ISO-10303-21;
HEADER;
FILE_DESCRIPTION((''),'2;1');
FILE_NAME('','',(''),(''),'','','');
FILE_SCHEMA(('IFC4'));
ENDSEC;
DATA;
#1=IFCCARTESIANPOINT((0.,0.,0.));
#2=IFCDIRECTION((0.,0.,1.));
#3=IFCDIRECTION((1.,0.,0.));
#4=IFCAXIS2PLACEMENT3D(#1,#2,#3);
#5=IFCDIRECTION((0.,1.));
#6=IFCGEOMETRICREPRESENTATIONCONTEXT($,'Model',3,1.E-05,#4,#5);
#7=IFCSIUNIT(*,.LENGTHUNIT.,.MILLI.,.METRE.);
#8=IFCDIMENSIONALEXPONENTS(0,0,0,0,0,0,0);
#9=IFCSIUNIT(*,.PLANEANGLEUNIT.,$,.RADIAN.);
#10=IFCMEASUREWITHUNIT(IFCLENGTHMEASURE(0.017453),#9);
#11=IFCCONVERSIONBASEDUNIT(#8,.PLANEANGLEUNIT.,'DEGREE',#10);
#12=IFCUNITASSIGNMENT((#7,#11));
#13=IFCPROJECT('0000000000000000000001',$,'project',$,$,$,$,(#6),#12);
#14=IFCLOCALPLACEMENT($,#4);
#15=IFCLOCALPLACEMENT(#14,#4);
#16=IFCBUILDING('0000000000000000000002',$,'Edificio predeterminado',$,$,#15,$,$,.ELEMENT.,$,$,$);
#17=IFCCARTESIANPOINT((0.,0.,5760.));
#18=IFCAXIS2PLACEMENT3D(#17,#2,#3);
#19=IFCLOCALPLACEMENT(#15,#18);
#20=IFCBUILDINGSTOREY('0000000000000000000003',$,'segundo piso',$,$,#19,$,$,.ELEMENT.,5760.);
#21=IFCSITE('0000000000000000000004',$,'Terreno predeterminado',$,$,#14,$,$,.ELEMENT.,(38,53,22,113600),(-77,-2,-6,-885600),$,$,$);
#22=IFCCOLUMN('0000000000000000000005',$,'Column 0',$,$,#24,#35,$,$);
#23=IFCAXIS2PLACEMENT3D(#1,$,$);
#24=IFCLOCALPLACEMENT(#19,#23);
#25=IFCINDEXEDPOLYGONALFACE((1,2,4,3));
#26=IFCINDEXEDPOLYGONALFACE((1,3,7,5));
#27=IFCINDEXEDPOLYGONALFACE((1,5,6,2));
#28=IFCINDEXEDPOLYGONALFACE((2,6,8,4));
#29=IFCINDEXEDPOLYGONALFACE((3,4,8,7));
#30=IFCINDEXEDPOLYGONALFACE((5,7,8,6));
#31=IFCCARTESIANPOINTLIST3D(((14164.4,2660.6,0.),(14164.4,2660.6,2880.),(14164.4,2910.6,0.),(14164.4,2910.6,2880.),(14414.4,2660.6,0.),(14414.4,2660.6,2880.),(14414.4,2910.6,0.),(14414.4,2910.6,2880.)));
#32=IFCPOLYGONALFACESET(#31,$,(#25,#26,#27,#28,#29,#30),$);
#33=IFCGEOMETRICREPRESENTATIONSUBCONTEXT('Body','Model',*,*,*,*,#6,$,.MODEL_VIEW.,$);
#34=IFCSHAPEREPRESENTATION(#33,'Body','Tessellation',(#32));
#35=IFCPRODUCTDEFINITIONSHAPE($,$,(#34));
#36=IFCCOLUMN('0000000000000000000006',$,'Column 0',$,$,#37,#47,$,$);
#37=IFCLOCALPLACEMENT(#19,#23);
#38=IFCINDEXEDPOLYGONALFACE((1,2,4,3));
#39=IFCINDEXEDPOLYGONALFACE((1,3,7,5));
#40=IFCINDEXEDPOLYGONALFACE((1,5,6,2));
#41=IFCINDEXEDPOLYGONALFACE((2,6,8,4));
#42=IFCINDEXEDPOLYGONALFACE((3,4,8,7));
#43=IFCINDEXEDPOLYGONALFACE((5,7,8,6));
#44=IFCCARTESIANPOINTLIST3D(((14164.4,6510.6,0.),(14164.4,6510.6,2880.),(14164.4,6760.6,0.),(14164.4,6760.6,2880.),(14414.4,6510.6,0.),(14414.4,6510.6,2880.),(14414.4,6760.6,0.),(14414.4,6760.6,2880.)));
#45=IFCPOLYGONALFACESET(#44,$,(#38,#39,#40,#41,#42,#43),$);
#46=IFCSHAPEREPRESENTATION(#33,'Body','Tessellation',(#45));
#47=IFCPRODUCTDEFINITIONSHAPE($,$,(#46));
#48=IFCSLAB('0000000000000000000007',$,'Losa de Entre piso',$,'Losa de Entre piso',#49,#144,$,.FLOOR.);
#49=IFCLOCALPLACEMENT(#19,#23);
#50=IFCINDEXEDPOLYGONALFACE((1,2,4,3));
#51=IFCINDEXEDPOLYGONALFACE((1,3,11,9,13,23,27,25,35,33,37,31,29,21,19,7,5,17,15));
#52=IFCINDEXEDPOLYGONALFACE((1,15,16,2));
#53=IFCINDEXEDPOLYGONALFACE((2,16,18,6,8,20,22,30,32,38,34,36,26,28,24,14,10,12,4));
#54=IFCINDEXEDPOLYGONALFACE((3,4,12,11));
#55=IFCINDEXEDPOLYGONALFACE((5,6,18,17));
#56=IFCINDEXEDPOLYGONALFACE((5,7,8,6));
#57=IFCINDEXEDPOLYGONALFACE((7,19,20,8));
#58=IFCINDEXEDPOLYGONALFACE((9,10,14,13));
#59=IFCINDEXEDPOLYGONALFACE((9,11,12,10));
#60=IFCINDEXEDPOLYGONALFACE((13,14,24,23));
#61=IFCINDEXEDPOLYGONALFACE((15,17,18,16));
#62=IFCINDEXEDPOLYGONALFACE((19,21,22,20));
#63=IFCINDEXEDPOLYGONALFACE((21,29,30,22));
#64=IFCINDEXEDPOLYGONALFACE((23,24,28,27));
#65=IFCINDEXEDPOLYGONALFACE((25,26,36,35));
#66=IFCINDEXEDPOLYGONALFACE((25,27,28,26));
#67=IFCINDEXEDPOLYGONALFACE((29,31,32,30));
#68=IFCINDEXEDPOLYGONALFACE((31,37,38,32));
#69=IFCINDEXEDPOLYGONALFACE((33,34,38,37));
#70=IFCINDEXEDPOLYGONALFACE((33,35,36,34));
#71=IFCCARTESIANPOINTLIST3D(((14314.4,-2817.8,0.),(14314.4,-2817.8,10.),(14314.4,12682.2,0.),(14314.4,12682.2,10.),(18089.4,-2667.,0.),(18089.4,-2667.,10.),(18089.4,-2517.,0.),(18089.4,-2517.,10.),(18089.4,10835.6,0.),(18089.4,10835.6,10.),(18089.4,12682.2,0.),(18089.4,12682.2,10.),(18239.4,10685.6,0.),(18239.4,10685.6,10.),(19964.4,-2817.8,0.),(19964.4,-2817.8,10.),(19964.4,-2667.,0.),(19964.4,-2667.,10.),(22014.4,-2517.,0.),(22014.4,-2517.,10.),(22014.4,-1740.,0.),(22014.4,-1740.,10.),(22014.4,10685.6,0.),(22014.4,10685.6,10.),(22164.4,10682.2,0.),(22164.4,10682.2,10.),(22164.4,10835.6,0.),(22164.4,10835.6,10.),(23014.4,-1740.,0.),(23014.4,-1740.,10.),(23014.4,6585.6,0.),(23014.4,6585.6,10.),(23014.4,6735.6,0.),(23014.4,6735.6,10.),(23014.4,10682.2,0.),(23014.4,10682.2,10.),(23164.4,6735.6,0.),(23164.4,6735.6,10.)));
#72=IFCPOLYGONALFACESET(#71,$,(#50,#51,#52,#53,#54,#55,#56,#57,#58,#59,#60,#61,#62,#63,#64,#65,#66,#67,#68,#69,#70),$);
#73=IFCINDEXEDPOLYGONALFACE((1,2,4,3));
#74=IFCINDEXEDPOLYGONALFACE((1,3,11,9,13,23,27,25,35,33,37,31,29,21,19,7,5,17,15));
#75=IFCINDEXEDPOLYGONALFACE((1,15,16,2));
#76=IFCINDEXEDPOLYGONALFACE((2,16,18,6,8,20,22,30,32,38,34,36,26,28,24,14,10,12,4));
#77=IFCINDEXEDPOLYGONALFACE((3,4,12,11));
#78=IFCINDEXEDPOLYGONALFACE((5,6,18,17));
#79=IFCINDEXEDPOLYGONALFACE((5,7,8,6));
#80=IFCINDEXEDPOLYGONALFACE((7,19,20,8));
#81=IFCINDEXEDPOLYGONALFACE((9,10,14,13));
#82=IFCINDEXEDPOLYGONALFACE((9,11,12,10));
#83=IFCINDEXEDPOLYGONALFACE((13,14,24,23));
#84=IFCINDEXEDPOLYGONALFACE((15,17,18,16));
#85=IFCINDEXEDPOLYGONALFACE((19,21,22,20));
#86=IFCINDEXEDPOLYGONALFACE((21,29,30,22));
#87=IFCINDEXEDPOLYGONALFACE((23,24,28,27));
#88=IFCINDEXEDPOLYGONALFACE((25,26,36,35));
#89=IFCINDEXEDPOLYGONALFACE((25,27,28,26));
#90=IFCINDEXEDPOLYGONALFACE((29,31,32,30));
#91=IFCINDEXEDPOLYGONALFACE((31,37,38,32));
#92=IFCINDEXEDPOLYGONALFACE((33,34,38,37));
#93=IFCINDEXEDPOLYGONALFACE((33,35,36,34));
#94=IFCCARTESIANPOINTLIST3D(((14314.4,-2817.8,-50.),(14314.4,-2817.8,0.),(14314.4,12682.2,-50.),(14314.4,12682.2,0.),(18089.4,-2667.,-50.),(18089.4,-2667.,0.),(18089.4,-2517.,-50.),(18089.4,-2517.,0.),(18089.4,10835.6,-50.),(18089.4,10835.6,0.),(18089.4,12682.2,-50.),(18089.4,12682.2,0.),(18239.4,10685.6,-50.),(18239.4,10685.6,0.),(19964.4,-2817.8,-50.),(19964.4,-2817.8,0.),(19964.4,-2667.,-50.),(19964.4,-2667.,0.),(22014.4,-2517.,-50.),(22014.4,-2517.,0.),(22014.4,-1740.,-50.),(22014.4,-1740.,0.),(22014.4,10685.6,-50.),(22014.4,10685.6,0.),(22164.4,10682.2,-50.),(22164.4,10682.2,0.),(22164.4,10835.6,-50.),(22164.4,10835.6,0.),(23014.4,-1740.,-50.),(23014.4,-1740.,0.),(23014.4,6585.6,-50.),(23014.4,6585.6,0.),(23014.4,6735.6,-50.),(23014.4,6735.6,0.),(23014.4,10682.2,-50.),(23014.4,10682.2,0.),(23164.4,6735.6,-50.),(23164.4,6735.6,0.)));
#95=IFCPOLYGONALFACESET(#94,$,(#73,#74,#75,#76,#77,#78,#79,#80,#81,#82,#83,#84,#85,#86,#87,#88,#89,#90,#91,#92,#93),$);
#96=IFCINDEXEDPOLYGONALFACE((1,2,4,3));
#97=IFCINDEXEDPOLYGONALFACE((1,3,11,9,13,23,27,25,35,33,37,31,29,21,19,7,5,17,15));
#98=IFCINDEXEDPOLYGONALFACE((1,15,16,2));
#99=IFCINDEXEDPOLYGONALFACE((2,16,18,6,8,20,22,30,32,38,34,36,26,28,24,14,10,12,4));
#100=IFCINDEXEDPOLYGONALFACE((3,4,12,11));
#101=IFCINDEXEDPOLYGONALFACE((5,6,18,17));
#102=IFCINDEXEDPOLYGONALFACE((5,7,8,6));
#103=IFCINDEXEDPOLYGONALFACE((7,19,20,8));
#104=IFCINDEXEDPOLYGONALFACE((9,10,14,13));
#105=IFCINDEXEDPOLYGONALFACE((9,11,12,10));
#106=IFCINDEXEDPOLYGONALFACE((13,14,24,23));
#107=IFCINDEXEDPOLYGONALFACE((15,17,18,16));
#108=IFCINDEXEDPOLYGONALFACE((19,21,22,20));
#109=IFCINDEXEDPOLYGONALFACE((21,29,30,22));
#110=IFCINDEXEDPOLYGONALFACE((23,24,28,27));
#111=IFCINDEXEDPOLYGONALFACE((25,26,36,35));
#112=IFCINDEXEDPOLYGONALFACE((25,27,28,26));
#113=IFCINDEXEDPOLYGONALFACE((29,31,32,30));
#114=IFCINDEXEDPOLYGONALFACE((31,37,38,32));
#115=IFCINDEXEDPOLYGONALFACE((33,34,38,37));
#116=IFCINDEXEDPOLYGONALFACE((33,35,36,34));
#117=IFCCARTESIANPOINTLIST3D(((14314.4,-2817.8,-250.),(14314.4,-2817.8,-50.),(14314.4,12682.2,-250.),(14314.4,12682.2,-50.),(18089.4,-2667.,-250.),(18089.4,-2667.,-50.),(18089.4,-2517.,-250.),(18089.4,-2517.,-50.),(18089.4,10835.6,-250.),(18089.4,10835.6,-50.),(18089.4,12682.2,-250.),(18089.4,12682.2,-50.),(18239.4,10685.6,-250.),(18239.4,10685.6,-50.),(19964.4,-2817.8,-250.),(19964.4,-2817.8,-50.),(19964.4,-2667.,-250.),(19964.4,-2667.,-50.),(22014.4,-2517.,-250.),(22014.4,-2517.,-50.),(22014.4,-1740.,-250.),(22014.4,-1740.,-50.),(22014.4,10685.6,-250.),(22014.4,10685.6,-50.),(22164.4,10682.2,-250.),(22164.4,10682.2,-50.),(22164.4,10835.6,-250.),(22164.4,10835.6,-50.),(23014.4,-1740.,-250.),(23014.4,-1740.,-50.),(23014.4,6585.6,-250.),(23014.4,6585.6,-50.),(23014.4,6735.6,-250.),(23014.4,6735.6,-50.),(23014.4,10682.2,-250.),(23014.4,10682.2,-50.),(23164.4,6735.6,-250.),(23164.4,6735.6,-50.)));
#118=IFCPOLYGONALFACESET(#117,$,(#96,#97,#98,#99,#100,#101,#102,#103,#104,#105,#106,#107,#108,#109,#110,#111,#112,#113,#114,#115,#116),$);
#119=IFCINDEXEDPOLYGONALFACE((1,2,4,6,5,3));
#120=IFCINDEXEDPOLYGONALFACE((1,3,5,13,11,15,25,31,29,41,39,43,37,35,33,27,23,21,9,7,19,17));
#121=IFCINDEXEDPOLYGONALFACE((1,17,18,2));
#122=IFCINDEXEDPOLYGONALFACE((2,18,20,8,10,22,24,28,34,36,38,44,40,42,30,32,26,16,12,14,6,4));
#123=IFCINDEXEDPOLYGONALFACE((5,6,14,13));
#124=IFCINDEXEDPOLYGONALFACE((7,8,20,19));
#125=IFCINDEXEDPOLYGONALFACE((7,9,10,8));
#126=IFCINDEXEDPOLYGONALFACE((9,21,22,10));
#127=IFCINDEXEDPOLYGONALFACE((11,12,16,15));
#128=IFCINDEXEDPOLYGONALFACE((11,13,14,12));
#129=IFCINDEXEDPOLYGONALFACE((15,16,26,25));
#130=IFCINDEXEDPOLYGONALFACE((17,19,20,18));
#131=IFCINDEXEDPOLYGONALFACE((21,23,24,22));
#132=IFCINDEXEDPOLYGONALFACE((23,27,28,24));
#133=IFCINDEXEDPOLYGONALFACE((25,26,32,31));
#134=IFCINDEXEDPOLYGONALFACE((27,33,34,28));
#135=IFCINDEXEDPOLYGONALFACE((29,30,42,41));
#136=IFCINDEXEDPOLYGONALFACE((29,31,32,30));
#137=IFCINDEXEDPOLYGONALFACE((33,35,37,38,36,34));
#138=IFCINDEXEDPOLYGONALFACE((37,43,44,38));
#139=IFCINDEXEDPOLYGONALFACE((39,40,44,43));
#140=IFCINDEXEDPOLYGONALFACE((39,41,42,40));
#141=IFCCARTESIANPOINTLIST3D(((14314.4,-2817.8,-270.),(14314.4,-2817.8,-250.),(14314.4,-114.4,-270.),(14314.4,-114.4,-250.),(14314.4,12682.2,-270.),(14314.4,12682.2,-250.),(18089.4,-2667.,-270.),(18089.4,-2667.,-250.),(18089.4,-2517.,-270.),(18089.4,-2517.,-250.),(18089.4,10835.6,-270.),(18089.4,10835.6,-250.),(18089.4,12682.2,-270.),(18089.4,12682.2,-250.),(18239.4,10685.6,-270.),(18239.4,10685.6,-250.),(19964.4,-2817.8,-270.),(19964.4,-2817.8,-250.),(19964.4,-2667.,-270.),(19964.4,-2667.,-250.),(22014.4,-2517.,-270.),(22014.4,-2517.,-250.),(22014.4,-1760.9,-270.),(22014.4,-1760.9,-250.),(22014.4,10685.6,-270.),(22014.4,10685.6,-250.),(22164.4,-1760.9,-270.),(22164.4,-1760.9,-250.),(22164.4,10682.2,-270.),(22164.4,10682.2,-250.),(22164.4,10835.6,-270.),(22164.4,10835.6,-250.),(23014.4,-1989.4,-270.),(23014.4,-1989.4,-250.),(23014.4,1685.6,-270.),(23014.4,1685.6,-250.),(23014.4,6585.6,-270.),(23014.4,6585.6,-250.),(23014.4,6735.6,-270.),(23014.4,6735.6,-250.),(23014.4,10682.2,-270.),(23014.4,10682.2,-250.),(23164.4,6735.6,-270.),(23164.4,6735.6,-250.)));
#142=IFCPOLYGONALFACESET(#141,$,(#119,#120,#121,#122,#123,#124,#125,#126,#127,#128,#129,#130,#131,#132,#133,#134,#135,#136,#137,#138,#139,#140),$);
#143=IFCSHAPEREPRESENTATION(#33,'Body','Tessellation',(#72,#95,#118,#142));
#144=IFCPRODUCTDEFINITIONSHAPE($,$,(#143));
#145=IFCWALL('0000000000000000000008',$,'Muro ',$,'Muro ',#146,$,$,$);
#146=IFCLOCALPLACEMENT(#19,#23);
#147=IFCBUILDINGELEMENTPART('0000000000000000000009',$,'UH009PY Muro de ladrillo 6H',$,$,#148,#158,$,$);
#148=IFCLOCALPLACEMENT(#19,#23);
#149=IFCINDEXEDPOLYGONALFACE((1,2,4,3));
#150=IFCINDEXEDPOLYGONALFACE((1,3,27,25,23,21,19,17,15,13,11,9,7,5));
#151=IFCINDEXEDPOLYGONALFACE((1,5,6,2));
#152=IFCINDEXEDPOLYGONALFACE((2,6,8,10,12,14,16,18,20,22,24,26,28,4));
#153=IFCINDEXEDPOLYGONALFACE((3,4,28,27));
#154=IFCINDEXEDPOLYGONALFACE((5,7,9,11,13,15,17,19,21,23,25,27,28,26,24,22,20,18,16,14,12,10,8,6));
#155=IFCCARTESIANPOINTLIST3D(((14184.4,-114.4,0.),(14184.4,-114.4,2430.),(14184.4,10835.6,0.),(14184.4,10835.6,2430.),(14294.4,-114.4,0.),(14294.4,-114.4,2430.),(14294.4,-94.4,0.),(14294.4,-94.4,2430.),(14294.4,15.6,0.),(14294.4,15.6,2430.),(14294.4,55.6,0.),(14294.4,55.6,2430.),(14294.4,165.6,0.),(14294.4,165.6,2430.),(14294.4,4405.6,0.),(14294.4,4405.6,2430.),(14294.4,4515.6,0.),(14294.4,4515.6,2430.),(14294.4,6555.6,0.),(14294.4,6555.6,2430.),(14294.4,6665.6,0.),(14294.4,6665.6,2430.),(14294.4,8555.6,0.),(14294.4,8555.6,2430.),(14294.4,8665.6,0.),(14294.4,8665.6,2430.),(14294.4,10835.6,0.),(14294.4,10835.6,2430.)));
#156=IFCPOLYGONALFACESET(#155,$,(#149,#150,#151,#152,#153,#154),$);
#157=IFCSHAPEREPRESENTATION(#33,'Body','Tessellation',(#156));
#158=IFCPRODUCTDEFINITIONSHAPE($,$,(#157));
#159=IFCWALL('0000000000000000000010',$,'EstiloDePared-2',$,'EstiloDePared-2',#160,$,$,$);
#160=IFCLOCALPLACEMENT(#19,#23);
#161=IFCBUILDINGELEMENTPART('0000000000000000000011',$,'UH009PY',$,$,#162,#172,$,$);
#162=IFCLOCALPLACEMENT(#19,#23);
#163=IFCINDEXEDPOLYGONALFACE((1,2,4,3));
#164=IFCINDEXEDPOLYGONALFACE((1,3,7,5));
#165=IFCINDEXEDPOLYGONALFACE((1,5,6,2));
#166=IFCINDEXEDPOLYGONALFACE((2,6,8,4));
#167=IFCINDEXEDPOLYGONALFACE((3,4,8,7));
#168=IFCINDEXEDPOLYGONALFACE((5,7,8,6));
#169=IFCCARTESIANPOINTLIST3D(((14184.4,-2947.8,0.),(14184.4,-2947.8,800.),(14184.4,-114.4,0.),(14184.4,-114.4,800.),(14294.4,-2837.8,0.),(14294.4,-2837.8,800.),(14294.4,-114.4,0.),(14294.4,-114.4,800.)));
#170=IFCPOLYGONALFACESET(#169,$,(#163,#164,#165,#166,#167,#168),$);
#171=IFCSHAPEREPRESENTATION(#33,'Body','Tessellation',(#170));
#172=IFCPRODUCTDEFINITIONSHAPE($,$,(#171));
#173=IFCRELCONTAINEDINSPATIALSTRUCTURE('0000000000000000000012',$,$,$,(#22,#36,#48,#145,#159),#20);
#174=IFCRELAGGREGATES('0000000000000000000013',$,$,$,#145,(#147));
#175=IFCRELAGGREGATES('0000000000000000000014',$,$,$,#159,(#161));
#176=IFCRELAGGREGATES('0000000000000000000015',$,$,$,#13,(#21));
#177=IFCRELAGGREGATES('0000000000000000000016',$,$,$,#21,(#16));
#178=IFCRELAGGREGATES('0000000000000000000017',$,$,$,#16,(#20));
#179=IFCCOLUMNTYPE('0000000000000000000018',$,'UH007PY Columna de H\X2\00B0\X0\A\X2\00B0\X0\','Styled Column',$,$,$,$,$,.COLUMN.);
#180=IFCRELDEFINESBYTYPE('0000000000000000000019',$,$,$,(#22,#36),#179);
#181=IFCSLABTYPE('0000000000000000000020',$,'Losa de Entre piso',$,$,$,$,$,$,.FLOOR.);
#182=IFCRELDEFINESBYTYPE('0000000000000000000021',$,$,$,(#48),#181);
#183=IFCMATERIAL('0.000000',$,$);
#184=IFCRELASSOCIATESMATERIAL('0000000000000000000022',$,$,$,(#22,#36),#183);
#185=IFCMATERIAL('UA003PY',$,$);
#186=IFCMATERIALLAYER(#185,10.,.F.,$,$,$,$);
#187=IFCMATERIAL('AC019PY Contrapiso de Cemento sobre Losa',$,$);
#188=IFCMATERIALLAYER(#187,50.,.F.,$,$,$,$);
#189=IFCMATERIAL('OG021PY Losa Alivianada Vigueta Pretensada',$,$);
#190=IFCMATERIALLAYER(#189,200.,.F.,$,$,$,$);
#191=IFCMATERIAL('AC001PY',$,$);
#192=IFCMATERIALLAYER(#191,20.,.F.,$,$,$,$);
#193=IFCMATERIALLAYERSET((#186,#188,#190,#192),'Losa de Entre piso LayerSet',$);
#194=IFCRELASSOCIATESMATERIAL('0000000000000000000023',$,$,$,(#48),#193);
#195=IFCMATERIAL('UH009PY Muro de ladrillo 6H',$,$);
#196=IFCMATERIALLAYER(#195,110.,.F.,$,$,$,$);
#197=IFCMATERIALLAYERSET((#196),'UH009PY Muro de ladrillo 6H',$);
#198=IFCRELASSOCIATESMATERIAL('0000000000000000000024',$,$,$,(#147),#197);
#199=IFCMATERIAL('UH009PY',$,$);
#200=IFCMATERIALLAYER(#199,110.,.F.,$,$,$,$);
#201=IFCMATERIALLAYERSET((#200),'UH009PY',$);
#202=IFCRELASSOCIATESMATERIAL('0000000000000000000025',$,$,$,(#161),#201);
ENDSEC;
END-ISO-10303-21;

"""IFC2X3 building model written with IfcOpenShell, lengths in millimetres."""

from ifc_helpers import new_model, entity, si_unit, converted_unit, direction, frame, origin_with_axes, place, context, subcontext, project, spatial, polyline, outline, extrude, material, layer, layer_set, layer_usage, type_object, element, aggregate, save


model = new_model("IFC2X3")

# Units and contexts
model_context = context("Model", 3, precision=1e-05, world=origin_with_axes(), true_north=direction((0.0, 1.0)))
body_context = subcontext(model_context, "Body", "Model", "MODEL_VIEW")
ifc_project = project(units=[si_unit("LENGTHUNIT", "METRE", prefix="MILLI"), converted_unit("PLANEANGLEUNIT", "DEGREE", entity("IfcLengthMeasure", 0.017453), si_unit("PLANEANGLEUNIT", "RADIAN"), dimensions=[0, 0, 0, 0, 0, 0, 0])], contexts=[model_context])

# Site, building, storey
site_placement = place(None, origin_with_axes())
site = spatial("IfcSite", under=ifc_project, at=site_placement, Name="Terreno predeterminado", CompositionType="ELEMENT", RefLatitude=(38, 53, 22, 113600), RefLongitude=(-77, -2, -6, -885600))
building_placement = place(site_placement, origin_with_axes())
building = spatial("IfcBuilding", under=site, at=building_placement, Name="Edificio predeterminado", CompositionType="ELEMENT")
storey_placement = place(building_placement, frame((0.0, 0.0, 5760.0), z_axis=(0.0, 0.0, 1.0), x_axis=(1.0, 0.0, 0.0)))
storey = spatial("IfcBuildingStorey", under=building, at=storey_placement, Name="segundo piso", CompositionType="ELEMENT", Elevation=5760.0)

# Columns
ifc_material_1 = material(Name="0.000000")
column_type = type_object("IfcColumnType", Name="UH007PY Columna de H°A°", Description="Styled Column", PredefinedType="COLUMN")
for number, where, z_axis, x_axis, name in (
    (1, (14289.4, 2785.6, 0.0), (0.0, 0.0, 1.0), (1.0, 0.0, 0.0), "Column 0"),
    (2, (14289.4, 6635.6, 0.0), (0.0, 0.0, 1.0), (1.0, 0.0, 0.0), "Column 0"),
):
    element("IfcColumn", number, at=place(storey_placement, frame(where, z_axis=z_axis, x_axis=x_axis)), inside=storey, type_object=column_type, material=ifc_material_1, Name=name, context=body_context, shape_type="SweptSolid", body=[
        extrude(outline(polyline([(-125.0, -125.0), (125.0, -125.0), (125.0, 125.0), (-125.0, 125.0), (-125.0, -125.0)])), origin_with_axes(), (0.0, 0.0, 1.0), 2880.0),
    ])

# Slab
ifc_material_2 = material(Name="UA003PY")
ifc_layer_1 = layer(ifc_material_2, 10.0, ventilated=False)
ifc_material_3 = material(Name="AC019PY Contrapiso de Cemento sobre Losa")
ifc_layer_2 = layer(ifc_material_3, 50.0, ventilated=False)
ifc_material_4 = material(Name="OG021PY Losa Alivianada Vigueta Pretensada")
ifc_layer_3 = layer(ifc_material_4, 200.0, ventilated=False)
ifc_material_5 = material(Name="AC001PY")
ifc_layer_4 = layer(ifc_material_5, 20.0, ventilated=False)
ifc_layer_set_1 = layer_set([ifc_layer_1, ifc_layer_2, ifc_layer_3, ifc_layer_4], Name="Losa de Entre piso LayerSet")
ifc_layer_usage_1 = layer_usage(ifc_layer_set_1, "AXIS3", "POSITIVE", 0.0)
slab_type = type_object("IfcSlabType", Name="Losa de Entre piso", PredefinedType="FLOOR")
slab_placement = place(storey_placement, frame((0.0, 0.0, -5760.0), z_axis=(0.0, 0.0, 1.0), x_axis=(1.0, 0.0, 0.0)))
element("IfcSlab", 3, at=slab_placement, inside=storey, type_object=slab_type, material=ifc_layer_usage_1, Name="Losa de Entre piso", ObjectType="Losa de Entre piso", PredefinedType="FLOOR", context=body_context, shape_type="SweptSolid", body=[
    extrude(outline(polyline([(0.0, -777.0), (-1000.0, -777.0), (-1000.0, -9102.6), (-1150.0, -9252.6), (-1000.0, -9252.6), (-1000.0, -13199.1), (-150.0, -13199.1), (-150.0, -13352.6), (0.0, -13202.6), (3775.0, -13202.6), (3925.0, -13352.6), (3925.0, -15199.1), (7700.0, -15199.1), (7700.0, 300.9), (2050.0, 300.9), (2050.0, 150.0), (3925.0, 150.0), (3925.0, 0.0), (0.0, 0.0), (0.0, -777.0)])), frame((22014.4, -2517.0, 5760.0), z_axis=(0.0, 0.0, 1.0), x_axis=(-1.0, 0.0, 0.0)), (0.0, 0.0, 1.0), 10.0),
    extrude(outline(polyline([(0.0, -777.0), (-1000.0, -777.0), (-1000.0, -9102.6), (-1150.0, -9252.6), (-1000.0, -9252.6), (-1000.0, -13199.1), (-150.0, -13199.1), (-150.0, -13352.6), (0.0, -13202.6), (3775.0, -13202.6), (3925.0, -13352.6), (3925.0, -15199.1), (7700.0, -15199.1), (7700.0, 300.9), (2050.0, 300.9), (2050.0, 150.0), (3925.0, 150.0), (3925.0, 0.0), (0.0, 0.0), (0.0, -777.0)])), frame((22014.4, -2517.0, 5710.0), z_axis=(0.0, 0.0, 1.0), x_axis=(-1.0, 0.0, 0.0)), (0.0, 0.0, 1.0), 50.0),
    extrude(outline(polyline([(0.0, -777.0), (-1000.0, -777.0), (-1000.0, -9102.6), (-1150.0, -9252.6), (-1000.0, -9252.6), (-1000.0, -13199.1), (-150.0, -13199.1), (-150.0, -13352.6), (0.0, -13202.6), (3775.0, -13202.6), (3925.0, -13352.6), (3925.0, -15199.1), (7700.0, -15199.1), (7700.0, 300.9), (2050.0, 300.9), (2050.0, 150.0), (3925.0, 150.0), (3925.0, 0.0), (0.0, 0.0), (0.0, -777.0)])), frame((22014.4, -2517.0, 5510.0), z_axis=(0.0, 0.0, 1.0), x_axis=(-1.0, 0.0, 0.0)), (0.0, 0.0, 1.0), 200.0),
    extrude(outline(polyline([(-1305.7, 1305.7), (-3975.1, -1363.6), (5073.5, -10412.1), (6985.1, -12323.8), (10980.3, -8328.6), (10873.6, -8221.9), (9547.8, -9547.8), (9441.7, -9441.7), (12217.1, -6666.3), (11682.5, -6131.7), (11788.6, -6025.7), (12551.1, -5586.1), (9952.5, -2987.5), (6487.7, 477.3), (6487.7, 689.4), (6381.6, 583.4), (3591.0, 3374.0), (2990.0, 2773.0), (2881.5, 2881.5), (2881.5, 2669.3), (212.1, 0.0), (0.0, 0.0), (-1305.7, 1305.7)])), frame((18089.4, 10835.6, 5490.0), z_axis=(0.0, 0.0, 1.0), x_axis=(0.707107, -0.707107, 0.0)), (0.0, 0.0, 1.0), 20.0),
])

# Walls, building element parts
wall_1_placement = place(storey_placement, frame((14239.4, 10835.6, 0.0), z_axis=(0.0, 0.0, 1.0), x_axis=(0.0, -1.0, 0.0)))
wall_1 = element("IfcWall", 4, at=wall_1_placement, inside=storey, Name="Muro ", ObjectType="Muro ")
ifc_material_6 = material(Name="UH009PY Muro de ladrillo 6H")
ifc_layer_5 = layer(ifc_material_6, 110.0, ventilated=False)
ifc_layer_set_2 = layer_set([ifc_layer_5], Name="UH009PY Muro de ladrillo 6H")
ifc_layer_usage_2 = layer_usage(ifc_layer_set_2, "AXIS2", "NEGATIVE", -55.0)
building_element_part_1_placement = place(wall_1_placement, origin_with_axes())
building_element_part_1 = element("IfcBuildingElementPart", 5, at=building_element_part_1_placement, material=ifc_layer_usage_2, Name="UH009PY Muro de ladrillo 6H", context=body_context, shape_type="SweptSolid", body=[
    extrude(outline(polyline([(4280.0, 55.0), (6320.0, 55.0), (6430.0, 55.0), (10670.0, 55.0), (10780.0, 55.0), (10820.0, 55.0), (10930.0, 55.0), (10950.0, 55.0), (10950.0, -55.0), (0.0, -55.0), (0.0, 55.0), (2170.0, 55.0), (2280.0, 55.0), (4170.0, 55.0), (4280.0, 55.0)])), origin_with_axes(), (0.0, 0.0, 1.0), 2430.0),
])
aggregate(wall_1, [building_element_part_1])
wall_2_placement = place(storey_placement, frame((14239.4, -2892.8, 0.0), z_axis=(0.0, 0.0, 1.0), x_axis=(0.0, 1.0, 0.0)))
wall_2 = element("IfcWall", 6, at=wall_2_placement, inside=storey, Name="EstiloDePared-2", ObjectType="EstiloDePared-2")
ifc_material_7 = material(Name="UH009PY")
ifc_layer_6 = layer(ifc_material_7, 110.0, ventilated=False)
ifc_layer_set_3 = layer_set([ifc_layer_6], Name="UH009PY")
ifc_layer_usage_3 = layer_usage(ifc_layer_set_3, "AXIS2", "NEGATIVE", -55.0)
building_element_part_2_placement = place(wall_2_placement, origin_with_axes())
building_element_part_2 = element("IfcBuildingElementPart", 7, at=building_element_part_2_placement, material=ifc_layer_usage_3, Name="UH009PY", context=body_context, shape_type="SweptSolid", body=[
    extrude(outline(polyline([(2778.4, 55.0), (2778.4, -55.0), (55.0, -55.0), (-55.0, 55.0), (2778.4, 55.0)])), origin_with_axes(), (0.0, 0.0, 1.0), 800.0),
])
aggregate(wall_2, [building_element_part_2])

save(model, "model.ifc")
